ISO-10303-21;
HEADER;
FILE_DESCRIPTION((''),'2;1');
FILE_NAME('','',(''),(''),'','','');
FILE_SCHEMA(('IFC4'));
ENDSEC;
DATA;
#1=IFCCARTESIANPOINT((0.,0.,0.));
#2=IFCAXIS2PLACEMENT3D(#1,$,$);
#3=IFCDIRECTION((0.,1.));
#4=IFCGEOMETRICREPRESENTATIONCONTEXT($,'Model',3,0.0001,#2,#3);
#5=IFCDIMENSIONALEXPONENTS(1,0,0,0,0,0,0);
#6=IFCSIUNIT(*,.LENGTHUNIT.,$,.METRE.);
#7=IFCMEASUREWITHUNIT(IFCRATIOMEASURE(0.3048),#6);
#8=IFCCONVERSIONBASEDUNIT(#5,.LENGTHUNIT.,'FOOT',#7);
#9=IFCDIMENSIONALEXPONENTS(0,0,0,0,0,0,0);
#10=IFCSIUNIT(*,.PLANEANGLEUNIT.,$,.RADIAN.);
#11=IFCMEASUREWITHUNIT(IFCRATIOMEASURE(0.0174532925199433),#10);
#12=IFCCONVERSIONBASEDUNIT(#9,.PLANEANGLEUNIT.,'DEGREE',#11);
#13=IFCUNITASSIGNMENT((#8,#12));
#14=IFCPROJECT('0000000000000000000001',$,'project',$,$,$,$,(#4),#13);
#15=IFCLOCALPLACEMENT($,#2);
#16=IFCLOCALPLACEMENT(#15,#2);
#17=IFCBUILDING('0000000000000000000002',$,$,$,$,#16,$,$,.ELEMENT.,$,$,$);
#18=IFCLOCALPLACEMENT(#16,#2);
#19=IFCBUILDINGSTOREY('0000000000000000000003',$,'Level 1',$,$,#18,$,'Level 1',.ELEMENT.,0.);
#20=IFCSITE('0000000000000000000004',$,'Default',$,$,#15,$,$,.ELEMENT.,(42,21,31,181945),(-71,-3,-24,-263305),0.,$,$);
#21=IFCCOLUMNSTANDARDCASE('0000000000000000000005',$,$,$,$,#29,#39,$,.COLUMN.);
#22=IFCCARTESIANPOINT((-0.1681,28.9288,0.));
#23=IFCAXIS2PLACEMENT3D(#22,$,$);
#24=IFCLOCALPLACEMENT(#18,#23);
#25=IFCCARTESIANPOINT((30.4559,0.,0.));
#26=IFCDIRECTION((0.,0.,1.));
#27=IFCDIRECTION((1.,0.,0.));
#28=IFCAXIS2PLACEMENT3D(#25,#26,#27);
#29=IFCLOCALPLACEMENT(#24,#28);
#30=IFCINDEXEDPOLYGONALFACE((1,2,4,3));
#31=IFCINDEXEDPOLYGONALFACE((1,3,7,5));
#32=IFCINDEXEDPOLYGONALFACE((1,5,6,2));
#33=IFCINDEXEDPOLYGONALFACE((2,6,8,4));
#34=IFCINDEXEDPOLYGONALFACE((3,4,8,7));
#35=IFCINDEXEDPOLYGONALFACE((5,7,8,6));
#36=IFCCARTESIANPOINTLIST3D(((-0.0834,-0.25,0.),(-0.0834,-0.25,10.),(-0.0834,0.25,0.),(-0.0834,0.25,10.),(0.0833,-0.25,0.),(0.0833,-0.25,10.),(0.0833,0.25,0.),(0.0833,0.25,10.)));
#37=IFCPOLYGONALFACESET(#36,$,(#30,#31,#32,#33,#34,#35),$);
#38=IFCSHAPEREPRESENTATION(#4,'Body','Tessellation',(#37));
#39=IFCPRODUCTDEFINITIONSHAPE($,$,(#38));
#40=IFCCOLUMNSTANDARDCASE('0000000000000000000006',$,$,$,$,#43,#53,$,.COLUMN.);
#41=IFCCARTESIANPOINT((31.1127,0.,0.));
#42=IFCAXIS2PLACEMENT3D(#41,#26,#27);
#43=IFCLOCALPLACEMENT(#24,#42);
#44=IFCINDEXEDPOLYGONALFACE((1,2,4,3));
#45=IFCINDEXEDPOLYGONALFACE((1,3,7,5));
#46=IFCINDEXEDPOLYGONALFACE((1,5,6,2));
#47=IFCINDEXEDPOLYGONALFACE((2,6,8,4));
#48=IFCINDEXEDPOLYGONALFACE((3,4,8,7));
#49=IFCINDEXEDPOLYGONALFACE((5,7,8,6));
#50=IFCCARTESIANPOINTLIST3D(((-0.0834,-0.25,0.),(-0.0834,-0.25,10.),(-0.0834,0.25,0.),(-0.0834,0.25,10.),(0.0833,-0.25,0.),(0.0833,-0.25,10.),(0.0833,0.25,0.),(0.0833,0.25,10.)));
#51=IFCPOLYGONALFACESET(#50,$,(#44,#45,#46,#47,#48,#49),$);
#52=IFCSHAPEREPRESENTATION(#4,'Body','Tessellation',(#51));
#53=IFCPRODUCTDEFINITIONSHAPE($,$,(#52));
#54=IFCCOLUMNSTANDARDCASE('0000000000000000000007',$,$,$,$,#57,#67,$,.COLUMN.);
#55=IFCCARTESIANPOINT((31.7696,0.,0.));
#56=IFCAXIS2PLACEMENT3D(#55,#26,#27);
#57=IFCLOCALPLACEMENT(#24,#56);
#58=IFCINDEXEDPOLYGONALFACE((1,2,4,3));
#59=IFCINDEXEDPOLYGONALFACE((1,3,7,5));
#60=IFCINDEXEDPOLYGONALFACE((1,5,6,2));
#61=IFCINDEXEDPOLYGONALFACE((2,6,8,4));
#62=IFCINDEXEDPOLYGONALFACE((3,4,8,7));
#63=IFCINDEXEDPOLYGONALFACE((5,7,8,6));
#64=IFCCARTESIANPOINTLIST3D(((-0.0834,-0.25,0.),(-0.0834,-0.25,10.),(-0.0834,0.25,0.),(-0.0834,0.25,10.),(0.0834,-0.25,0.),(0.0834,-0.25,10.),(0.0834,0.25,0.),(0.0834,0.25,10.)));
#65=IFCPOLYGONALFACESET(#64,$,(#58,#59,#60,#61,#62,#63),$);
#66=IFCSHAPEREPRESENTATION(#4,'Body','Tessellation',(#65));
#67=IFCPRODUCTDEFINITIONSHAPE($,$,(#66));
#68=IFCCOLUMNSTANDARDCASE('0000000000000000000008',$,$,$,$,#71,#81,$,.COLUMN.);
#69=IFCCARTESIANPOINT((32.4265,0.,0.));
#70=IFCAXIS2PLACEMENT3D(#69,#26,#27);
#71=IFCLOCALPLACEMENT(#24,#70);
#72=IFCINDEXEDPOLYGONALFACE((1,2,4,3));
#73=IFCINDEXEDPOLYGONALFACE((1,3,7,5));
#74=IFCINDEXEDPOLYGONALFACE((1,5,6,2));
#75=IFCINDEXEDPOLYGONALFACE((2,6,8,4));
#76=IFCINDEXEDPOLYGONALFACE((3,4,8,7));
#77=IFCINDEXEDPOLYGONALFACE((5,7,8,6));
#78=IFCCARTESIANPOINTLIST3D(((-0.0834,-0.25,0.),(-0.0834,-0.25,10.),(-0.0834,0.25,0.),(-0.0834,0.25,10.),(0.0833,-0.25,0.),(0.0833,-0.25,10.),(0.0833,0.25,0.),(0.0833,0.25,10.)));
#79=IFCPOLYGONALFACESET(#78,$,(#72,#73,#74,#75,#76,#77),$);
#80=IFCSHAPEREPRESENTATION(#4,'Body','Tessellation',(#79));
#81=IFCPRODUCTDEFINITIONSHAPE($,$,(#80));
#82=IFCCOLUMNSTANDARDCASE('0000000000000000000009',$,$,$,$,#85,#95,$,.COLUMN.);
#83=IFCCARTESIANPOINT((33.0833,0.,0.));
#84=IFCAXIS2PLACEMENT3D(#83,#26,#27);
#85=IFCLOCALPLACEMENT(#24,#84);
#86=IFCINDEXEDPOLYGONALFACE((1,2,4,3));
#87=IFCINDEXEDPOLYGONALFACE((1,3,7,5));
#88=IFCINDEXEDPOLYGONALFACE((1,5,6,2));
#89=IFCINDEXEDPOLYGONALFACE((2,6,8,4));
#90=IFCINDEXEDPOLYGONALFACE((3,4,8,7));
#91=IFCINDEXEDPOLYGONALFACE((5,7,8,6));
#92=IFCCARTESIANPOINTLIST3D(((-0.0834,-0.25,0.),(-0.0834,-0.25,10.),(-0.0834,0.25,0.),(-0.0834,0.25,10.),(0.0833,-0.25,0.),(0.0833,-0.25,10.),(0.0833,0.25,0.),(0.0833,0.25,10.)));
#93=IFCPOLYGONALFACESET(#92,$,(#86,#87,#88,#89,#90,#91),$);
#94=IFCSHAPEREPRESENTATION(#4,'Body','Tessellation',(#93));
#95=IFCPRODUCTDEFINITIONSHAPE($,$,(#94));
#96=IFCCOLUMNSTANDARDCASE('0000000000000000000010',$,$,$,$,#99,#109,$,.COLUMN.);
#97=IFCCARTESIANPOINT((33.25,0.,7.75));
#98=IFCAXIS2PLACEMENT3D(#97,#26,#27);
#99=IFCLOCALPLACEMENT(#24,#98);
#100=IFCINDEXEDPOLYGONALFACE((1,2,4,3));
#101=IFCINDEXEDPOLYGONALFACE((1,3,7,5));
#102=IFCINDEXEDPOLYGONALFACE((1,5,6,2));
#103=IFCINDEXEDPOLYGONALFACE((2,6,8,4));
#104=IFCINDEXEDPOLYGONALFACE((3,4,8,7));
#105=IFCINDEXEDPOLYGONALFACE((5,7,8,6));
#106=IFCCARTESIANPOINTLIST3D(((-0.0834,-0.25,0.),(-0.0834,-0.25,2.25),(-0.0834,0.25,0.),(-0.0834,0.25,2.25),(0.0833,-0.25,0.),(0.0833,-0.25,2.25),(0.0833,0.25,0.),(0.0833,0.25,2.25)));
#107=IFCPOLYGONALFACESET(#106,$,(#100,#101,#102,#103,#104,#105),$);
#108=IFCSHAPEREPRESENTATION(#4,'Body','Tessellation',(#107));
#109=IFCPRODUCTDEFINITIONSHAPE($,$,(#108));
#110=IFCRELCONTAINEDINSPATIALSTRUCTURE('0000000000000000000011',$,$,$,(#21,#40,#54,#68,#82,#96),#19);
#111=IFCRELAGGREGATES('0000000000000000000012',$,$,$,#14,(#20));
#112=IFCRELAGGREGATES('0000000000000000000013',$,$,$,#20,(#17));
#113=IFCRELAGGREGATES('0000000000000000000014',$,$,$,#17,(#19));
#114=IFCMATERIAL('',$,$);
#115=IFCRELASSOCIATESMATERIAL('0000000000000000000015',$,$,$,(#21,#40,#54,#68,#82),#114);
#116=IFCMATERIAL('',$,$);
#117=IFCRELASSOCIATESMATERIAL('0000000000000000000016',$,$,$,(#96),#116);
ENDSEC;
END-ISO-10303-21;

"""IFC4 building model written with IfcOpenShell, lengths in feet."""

from ifc_helpers import new_model, entity, si_unit, converted_unit, direction, frame, origin, place, context, project, spatial, rectangle, extrude, material, element, save


model = new_model("IFC4")

# Units and contexts
model_context = context("Model", 3, precision=0.0001, world=origin(), true_north=direction((0.0, 1.0)))
ifc_project = project(units=[converted_unit("LENGTHUNIT", "FOOT", entity("IfcRatioMeasure", 0.3048), si_unit("LENGTHUNIT", "METRE"), dimensions=[1, 0, 0, 0, 0, 0, 0]), converted_unit("PLANEANGLEUNIT", "DEGREE", entity("IfcRatioMeasure", 0.0174532925199433), si_unit("PLANEANGLEUNIT", "RADIAN"), dimensions=[0, 0, 0, 0, 0, 0, 0])], contexts=[model_context])

# Site, building, storey
site_placement = place(None, origin())
site = spatial("IfcSite", under=ifc_project, at=site_placement, Name="Default", CompositionType="ELEMENT", RefLatitude=(42, 21, 31, 181945), RefLongitude=(-71, -3, -24, -263305), RefElevation=0.0)
building_placement = place(site_placement, origin())
building = spatial("IfcBuilding", under=site, at=building_placement, CompositionType="ELEMENT")
storey_placement = place(building_placement, origin())
storey = spatial("IfcBuildingStorey", under=building, at=storey_placement, Name="Level 1", LongName="Level 1", CompositionType="ELEMENT", Elevation=0.0)

# Columns
ifc_material_1 = material(Name="")
placement = place(storey_placement, frame((-0.1681, 28.9288, 0.0)))
for number, where, z_axis, x_axis in (
    (1, (30.4559, 0.0, 0.0), (0.0, 0.0, 1.0), (1.0, 0.0, 0.0)),
    (2, (31.1127, 0.0, 0.0), (0.0, 0.0, 1.0), (1.0, 0.0, 0.0)),
    (3, (31.7696, 0.0, 0.0), (0.0, 0.0, 1.0), (1.0, 0.0, 0.0)),
    (4, (32.4265, 0.0, 0.0), (0.0, 0.0, 1.0), (1.0, 0.0, 0.0)),
    (5, (33.0833, 0.0, 0.0), (0.0, 0.0, 1.0), (1.0, 0.0, 0.0)),
):
    element("IfcColumnStandardCase", number, at=place(placement, frame(where, z_axis=z_axis, x_axis=x_axis)), inside=storey, material=ifc_material_1, PredefinedType="COLUMN", context=model_context, shape_type="SweptSolid", body=[
        extrude(rectangle(XDim=0.1667, YDim=0.5), origin(), (0.0, 0.0, 1.0), 10.0),
    ])
ifc_material_2 = material(Name="")
for number, where, z_axis, x_axis in (
    (6, (33.25, 0.0, 7.75), (0.0, 0.0, 1.0), (1.0, 0.0, 0.0)),
):
    element("IfcColumnStandardCase", number, at=place(placement, frame(where, z_axis=z_axis, x_axis=x_axis)), inside=storey, material=ifc_material_2, PredefinedType="COLUMN", context=model_context, shape_type="SweptSolid", body=[
        extrude(rectangle(XDim=0.1667, YDim=0.5), origin(), (0.0, 0.0, 1.0), 2.25),
    ])

save(model, "model.ifc")
